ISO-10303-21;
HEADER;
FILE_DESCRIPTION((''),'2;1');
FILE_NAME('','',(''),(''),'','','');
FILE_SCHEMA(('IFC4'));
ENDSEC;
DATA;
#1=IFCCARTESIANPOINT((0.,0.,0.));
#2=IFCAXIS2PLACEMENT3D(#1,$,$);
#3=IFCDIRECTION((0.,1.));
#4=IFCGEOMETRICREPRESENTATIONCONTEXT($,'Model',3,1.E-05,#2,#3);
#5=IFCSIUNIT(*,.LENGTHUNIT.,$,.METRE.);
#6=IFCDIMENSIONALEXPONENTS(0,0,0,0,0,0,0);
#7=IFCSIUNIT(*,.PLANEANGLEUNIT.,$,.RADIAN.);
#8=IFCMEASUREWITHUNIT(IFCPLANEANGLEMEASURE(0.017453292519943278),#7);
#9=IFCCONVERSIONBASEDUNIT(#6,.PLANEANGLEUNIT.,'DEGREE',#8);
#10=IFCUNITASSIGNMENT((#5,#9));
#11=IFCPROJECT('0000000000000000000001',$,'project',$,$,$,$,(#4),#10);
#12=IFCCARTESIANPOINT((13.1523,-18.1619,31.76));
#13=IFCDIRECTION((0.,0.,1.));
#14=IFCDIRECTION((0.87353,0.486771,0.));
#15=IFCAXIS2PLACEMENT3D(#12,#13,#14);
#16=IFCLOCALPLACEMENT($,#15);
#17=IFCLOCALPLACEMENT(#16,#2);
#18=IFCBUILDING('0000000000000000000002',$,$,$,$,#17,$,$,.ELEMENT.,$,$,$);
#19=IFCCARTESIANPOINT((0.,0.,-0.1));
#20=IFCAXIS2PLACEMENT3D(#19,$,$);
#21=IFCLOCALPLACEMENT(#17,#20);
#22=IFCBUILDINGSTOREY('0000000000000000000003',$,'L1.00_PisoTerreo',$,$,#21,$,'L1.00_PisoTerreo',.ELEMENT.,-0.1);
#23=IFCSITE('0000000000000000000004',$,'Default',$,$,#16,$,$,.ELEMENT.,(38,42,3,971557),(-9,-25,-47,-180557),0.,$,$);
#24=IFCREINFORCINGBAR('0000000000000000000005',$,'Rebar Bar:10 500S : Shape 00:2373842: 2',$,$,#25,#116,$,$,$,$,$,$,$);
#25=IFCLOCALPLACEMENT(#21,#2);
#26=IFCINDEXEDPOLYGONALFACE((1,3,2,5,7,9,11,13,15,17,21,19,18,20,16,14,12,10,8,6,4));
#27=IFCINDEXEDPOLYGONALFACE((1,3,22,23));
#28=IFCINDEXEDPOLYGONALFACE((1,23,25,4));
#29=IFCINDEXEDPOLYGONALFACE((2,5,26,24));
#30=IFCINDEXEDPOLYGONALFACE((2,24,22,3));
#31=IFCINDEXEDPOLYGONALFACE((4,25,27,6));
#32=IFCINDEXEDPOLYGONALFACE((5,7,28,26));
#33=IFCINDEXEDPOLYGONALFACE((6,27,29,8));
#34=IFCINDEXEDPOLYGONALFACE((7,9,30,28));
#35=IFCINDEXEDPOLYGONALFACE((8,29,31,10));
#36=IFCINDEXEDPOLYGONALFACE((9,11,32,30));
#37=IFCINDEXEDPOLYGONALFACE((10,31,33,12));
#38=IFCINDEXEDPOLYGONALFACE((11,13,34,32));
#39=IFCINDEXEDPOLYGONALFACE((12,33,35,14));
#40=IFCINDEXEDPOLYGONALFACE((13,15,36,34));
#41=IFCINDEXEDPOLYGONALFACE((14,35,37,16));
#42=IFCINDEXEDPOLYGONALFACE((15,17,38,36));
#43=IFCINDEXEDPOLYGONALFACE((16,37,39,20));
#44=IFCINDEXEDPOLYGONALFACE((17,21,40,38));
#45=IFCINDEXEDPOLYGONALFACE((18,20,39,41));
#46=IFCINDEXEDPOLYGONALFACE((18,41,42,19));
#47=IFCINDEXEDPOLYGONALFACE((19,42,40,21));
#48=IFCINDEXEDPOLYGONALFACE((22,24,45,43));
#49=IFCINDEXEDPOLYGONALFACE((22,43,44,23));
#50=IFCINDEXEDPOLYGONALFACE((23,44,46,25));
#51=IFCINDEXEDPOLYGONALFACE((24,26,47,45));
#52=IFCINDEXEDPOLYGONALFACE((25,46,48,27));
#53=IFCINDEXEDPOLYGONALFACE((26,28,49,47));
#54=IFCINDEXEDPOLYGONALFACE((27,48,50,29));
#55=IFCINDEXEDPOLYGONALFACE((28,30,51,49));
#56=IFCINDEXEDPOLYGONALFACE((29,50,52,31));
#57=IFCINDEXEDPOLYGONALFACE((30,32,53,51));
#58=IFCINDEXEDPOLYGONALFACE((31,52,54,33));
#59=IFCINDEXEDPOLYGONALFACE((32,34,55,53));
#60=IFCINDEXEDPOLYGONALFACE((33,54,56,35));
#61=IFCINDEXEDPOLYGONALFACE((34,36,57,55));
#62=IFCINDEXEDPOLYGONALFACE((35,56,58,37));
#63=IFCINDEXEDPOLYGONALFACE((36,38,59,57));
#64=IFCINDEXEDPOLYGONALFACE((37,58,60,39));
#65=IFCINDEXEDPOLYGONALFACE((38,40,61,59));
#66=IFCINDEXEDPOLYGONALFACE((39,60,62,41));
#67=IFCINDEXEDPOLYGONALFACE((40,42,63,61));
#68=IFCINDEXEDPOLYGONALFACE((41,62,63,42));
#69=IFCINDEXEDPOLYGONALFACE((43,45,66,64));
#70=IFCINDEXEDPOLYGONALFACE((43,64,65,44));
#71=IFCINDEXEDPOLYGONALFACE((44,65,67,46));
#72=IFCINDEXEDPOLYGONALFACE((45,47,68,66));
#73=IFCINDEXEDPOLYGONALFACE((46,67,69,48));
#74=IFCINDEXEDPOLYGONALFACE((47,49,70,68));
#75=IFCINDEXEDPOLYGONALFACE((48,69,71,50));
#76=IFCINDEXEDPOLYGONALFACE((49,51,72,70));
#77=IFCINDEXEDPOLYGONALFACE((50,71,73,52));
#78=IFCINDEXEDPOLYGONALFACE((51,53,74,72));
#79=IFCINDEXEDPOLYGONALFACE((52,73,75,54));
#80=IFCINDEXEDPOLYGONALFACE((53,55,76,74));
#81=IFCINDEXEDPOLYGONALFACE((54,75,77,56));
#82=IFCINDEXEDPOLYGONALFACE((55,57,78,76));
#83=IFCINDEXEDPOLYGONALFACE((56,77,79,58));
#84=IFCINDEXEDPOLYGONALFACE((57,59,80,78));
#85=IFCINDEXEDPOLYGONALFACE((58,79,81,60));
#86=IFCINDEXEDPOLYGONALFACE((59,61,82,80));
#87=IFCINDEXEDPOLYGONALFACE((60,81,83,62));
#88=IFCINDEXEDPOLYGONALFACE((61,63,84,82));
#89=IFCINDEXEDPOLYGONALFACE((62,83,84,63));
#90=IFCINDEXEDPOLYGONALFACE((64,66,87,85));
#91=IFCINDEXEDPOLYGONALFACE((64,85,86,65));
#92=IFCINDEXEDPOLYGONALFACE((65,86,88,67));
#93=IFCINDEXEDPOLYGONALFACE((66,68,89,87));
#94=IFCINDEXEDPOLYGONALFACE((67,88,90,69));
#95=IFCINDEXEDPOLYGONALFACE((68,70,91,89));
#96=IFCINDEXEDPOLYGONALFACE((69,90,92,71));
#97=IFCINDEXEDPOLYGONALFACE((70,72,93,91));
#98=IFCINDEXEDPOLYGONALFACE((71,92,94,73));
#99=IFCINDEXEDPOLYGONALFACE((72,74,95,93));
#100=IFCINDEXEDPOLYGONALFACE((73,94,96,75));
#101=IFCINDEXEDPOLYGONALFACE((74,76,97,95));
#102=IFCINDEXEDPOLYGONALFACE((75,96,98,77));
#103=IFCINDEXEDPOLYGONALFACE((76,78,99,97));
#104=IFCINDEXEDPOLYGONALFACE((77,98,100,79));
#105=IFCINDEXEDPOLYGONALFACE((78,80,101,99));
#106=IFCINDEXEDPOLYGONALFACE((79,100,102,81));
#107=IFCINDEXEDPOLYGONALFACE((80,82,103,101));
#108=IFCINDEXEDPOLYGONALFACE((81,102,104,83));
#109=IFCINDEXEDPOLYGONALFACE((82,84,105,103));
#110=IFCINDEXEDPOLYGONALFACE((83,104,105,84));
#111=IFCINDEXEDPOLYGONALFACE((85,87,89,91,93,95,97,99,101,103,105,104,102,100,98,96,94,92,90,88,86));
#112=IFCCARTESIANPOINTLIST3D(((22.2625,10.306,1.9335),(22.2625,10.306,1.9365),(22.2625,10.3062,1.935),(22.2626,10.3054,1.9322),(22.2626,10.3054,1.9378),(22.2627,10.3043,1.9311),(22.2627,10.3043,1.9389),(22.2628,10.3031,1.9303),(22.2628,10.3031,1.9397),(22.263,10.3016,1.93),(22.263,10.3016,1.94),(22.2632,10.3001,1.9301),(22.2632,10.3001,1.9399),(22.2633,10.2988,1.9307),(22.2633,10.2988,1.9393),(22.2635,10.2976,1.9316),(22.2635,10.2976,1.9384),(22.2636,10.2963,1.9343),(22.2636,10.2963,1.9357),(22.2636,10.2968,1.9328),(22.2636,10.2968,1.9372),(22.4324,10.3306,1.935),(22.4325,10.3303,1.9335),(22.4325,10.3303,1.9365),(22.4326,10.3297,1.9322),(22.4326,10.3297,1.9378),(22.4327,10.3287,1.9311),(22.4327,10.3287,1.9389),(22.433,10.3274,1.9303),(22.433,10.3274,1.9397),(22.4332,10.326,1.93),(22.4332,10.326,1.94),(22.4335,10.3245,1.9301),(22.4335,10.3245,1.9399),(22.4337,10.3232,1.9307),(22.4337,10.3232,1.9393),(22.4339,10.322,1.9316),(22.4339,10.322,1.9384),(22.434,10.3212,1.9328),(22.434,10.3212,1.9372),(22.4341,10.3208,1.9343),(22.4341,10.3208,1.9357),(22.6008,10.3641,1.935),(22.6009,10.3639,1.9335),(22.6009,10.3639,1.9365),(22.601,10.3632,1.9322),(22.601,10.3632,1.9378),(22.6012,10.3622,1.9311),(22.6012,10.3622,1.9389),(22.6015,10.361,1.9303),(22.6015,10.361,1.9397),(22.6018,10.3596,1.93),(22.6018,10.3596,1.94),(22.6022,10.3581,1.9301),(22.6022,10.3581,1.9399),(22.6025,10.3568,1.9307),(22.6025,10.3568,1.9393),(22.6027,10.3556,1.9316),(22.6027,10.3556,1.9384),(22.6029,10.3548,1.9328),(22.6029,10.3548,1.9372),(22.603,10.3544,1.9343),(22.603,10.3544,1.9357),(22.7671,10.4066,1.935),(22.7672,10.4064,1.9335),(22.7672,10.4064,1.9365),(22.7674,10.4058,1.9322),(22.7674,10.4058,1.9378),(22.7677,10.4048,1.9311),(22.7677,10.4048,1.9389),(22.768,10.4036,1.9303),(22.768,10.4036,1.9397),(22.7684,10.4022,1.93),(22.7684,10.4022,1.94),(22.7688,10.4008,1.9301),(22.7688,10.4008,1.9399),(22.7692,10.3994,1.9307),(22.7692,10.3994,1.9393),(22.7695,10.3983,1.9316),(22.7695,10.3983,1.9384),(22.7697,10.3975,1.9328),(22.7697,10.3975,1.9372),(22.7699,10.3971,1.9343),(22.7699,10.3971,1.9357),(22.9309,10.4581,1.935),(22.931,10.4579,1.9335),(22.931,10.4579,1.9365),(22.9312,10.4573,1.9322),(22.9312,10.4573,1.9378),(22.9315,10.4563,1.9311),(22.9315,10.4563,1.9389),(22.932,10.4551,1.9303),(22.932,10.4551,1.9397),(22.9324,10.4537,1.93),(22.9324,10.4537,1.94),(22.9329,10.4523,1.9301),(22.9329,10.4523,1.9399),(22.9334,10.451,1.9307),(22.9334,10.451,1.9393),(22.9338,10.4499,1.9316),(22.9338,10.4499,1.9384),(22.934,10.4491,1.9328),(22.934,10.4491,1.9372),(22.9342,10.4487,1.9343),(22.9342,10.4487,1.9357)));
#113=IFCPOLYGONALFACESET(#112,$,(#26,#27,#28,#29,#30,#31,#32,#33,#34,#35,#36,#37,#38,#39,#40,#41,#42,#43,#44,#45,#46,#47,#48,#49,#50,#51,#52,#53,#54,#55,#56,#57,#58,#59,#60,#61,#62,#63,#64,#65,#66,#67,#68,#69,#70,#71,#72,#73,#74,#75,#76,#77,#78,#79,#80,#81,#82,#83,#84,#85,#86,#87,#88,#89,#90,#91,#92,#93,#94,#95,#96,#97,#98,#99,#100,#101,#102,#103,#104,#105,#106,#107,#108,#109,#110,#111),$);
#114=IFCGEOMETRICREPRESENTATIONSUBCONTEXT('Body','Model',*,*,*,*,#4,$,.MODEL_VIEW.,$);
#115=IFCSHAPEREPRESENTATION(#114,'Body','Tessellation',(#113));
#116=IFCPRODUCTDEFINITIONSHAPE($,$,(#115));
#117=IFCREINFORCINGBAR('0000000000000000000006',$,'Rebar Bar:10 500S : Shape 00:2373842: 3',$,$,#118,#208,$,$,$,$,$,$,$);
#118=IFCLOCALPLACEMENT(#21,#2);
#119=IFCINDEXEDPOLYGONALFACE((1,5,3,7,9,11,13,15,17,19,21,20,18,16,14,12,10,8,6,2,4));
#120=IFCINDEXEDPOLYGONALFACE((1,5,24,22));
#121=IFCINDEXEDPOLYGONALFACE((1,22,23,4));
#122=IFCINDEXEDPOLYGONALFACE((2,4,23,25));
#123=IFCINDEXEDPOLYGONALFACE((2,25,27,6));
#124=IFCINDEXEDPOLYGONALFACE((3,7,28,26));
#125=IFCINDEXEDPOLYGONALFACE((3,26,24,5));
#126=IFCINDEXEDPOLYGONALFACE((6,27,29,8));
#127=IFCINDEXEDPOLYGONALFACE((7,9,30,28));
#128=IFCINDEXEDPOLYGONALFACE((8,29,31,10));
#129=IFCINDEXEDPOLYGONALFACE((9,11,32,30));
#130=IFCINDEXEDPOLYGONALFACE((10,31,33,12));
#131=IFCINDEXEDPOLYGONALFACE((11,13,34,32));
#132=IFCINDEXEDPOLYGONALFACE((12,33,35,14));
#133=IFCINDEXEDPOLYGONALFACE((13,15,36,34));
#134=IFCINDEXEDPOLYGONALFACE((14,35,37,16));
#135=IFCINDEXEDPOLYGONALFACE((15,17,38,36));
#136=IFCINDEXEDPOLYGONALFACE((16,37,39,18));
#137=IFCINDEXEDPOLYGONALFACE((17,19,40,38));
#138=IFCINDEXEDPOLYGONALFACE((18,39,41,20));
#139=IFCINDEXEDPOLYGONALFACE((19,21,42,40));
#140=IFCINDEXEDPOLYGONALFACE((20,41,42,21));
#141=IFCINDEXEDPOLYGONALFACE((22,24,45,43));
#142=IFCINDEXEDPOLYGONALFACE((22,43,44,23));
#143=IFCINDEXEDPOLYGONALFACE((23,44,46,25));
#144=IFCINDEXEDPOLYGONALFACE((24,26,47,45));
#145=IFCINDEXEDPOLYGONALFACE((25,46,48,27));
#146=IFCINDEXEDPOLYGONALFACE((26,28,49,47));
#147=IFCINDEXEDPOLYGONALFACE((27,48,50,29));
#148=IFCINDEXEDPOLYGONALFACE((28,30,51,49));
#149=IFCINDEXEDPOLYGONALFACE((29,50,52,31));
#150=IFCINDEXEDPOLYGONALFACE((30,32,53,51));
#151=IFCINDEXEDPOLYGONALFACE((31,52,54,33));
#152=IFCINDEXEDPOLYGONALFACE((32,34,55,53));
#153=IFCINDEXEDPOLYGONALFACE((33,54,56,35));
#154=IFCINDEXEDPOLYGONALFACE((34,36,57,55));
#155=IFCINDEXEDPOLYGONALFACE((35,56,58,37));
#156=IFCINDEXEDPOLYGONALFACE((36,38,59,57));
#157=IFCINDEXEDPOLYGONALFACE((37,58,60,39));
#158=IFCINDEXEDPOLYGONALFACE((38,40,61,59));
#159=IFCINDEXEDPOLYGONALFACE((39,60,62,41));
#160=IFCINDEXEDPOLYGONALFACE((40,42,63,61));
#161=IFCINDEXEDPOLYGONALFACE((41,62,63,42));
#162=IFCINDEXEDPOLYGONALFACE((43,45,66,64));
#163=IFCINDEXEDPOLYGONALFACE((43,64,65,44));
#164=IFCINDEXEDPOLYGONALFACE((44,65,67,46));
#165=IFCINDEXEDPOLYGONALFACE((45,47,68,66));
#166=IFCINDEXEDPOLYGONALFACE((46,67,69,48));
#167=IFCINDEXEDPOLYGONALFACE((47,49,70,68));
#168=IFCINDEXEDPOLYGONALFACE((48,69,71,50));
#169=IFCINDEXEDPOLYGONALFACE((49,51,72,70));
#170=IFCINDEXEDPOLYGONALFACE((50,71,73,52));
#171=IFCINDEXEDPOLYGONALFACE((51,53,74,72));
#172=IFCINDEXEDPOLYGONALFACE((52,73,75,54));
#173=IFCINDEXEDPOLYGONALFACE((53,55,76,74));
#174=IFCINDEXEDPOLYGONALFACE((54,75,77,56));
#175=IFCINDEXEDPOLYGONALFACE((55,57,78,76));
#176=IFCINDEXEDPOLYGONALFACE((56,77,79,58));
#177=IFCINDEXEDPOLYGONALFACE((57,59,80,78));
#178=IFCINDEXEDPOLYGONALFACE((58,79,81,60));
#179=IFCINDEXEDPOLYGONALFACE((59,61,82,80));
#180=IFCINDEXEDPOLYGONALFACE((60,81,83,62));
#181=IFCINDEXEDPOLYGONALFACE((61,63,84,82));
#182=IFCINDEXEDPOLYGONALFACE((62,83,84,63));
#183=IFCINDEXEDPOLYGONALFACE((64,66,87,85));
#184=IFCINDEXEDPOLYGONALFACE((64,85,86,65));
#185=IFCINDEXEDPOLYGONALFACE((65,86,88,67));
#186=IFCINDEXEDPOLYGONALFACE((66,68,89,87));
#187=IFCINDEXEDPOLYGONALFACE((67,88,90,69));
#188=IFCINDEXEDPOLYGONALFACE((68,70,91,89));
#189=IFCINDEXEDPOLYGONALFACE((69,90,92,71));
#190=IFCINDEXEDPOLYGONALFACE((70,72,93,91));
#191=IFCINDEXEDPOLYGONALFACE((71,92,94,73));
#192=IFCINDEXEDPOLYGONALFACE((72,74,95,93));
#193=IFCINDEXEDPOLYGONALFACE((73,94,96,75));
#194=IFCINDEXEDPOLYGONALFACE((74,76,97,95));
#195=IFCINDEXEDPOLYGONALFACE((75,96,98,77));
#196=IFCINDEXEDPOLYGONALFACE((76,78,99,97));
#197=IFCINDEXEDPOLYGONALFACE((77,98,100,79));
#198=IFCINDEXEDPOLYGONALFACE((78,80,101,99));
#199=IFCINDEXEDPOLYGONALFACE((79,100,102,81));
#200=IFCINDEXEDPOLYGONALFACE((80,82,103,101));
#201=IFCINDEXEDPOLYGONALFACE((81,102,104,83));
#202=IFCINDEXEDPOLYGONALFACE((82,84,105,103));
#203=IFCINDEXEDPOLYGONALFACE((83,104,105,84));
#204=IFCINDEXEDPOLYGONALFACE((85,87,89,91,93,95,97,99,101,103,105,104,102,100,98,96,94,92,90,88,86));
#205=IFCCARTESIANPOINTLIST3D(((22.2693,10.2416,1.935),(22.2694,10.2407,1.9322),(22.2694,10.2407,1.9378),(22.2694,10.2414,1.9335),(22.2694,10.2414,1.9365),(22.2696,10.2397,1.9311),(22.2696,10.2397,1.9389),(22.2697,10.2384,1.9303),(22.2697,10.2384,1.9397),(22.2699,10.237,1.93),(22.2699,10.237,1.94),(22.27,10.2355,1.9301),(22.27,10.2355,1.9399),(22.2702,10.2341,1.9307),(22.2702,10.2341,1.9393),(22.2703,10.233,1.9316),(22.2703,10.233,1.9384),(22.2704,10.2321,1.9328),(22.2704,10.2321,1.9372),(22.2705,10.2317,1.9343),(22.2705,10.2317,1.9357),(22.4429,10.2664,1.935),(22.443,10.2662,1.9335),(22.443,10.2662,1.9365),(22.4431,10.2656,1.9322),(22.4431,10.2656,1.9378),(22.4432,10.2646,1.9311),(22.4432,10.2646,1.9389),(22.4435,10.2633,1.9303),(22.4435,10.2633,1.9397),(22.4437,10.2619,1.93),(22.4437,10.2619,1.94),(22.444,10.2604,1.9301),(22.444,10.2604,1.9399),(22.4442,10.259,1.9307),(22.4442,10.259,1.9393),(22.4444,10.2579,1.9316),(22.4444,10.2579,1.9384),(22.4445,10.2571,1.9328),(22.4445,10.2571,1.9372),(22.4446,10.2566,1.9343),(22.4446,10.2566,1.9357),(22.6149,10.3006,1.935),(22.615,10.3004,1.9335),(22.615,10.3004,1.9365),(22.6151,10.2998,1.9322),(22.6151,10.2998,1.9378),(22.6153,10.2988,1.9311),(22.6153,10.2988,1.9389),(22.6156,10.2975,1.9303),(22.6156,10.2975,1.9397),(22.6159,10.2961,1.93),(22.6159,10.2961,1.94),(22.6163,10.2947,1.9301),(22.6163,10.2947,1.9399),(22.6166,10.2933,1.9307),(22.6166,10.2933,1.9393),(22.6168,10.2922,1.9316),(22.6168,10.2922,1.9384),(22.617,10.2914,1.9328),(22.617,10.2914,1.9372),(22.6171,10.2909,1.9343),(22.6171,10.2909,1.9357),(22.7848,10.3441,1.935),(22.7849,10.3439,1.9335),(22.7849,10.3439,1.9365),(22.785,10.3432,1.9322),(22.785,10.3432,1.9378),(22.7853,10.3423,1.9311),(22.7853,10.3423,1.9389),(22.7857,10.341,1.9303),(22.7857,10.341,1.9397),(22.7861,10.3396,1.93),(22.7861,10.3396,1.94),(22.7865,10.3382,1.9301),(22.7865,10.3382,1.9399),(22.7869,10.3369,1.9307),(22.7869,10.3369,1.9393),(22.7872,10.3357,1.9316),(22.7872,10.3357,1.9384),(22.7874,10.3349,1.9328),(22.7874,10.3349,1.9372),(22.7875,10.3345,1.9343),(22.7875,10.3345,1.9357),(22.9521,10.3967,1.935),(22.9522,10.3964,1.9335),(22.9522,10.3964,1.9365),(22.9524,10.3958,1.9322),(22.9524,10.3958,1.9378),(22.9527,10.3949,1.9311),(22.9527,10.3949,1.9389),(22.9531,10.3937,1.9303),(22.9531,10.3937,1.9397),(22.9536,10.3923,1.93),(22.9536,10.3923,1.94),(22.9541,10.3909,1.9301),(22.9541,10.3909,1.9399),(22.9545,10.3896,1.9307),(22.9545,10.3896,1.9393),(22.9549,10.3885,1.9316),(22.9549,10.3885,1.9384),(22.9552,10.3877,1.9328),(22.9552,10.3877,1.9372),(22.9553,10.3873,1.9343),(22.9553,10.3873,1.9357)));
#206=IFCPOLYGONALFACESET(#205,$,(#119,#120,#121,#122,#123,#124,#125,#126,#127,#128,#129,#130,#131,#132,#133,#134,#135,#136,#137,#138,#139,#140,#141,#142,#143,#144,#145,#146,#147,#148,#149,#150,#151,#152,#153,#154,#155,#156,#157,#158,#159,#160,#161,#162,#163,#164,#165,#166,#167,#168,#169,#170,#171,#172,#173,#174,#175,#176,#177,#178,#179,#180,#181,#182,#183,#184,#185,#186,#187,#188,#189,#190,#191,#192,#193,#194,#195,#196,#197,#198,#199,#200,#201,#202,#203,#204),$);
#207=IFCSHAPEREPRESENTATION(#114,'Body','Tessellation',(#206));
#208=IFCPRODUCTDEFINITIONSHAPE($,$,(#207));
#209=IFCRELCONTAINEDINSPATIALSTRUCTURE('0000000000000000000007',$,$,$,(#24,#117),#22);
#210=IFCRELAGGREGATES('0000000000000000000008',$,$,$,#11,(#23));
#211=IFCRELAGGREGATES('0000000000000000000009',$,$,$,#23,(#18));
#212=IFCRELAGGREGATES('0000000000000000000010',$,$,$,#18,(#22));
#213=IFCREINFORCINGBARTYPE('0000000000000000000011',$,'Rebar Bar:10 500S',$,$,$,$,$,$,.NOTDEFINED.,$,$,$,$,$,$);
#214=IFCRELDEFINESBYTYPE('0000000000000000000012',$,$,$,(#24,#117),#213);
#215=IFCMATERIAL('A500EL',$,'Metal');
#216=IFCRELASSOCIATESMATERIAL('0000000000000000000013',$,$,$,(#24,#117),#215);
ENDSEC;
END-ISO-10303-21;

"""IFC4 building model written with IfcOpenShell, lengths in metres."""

from ifc_helpers import new_model, entity, si_unit, converted_unit, direction, frame, origin, place, context, subcontext, project, spatial, material, type_object, element, save


model = new_model("IFC4")

# Units and contexts
model_context = context("Model", 3, precision=1e-05, world=origin(), true_north=direction((0.0, 1.0)))
body_context = subcontext(model_context, "Body", "Model", "MODEL_VIEW")
ifc_project = project(units=[si_unit("LENGTHUNIT", "METRE"), converted_unit("PLANEANGLEUNIT", "DEGREE", entity("IfcPlaneAngleMeasure", 0.017453292519943278), si_unit("PLANEANGLEUNIT", "RADIAN"), dimensions=[0, 0, 0, 0, 0, 0, 0])], contexts=[model_context])

# Site, building, storey
site_placement = place(None, frame((13.1523, -18.1619, 31.76), z_axis=(0.0, 0.0, 1.0), x_axis=(0.87353, 0.486771, 0.0)))
site = spatial("IfcSite", under=ifc_project, at=site_placement, Name="Default", CompositionType="ELEMENT", RefLatitude=(38, 42, 3, 971557), RefLongitude=(-9, -25, -47, -180557), RefElevation=0.0)
building_placement = place(site_placement, origin())
building = spatial("IfcBuilding", under=site, at=building_placement, CompositionType="ELEMENT")
storey_placement = place(building_placement, frame((0.0, 0.0, -0.1)))
storey = spatial("IfcBuildingStorey", under=building, at=storey_placement, Name="L1.00_PisoTerreo", LongName="L1.00_PisoTerreo", CompositionType="ELEMENT", Elevation=-0.1)

# Reinforcing bars
ifc_material = material(Name="A500EL", Category="Metal")
reinforcing_bar_type_1 = type_object("IfcReinforcingBarType", Name="Rebar Bar:10 500S", PredefinedType="NOTDEFINED")
reinforcing_bar_1_placement = place(storey_placement, origin())
element("IfcReinforcingBar", 1, at=reinforcing_bar_1_placement, inside=storey, type_object=reinforcing_bar_type_1, material=ifc_material, Name="Rebar Bar:10 500S : Shape 00:2373842: 2", context=body_context, shape_type="AdvancedSweptSolid", body=[
    entity("IfcSweptDiskSolid", entity("IfcIndexedPolyCurve", entity("IfcCartesianPointList3D", [[22.263, 10.3012, 1.935], [22.6019, 10.3592, 1.935], [22.9326, 10.4534, 1.935]]), [entity("IfcArcIndex", [1, 2, 3])], False), 0.005, None, 0.0, 12.3946),
])
reinforcing_bar_2_placement = place(storey_placement, origin())
element("IfcReinforcingBar", 2, at=reinforcing_bar_2_placement, inside=storey, type_object=reinforcing_bar_type_1, material=ifc_material, Name="Rebar Bar:10 500S : Shape 00:2373842: 3", context=body_context, shape_type="AdvancedSweptSolid", body=[
    entity("IfcSweptDiskSolid", entity("IfcIndexedPolyCurve", entity("IfcCartesianPointList3D", [[22.2699, 10.2366, 1.935], [22.616, 10.2957, 1.935], [22.9537, 10.3919, 1.935]]), [entity("IfcArcIndex", [1, 2, 3])], False), 0.005, None, 0.0, 12.4055),
])

save(model, "model.ifc")
